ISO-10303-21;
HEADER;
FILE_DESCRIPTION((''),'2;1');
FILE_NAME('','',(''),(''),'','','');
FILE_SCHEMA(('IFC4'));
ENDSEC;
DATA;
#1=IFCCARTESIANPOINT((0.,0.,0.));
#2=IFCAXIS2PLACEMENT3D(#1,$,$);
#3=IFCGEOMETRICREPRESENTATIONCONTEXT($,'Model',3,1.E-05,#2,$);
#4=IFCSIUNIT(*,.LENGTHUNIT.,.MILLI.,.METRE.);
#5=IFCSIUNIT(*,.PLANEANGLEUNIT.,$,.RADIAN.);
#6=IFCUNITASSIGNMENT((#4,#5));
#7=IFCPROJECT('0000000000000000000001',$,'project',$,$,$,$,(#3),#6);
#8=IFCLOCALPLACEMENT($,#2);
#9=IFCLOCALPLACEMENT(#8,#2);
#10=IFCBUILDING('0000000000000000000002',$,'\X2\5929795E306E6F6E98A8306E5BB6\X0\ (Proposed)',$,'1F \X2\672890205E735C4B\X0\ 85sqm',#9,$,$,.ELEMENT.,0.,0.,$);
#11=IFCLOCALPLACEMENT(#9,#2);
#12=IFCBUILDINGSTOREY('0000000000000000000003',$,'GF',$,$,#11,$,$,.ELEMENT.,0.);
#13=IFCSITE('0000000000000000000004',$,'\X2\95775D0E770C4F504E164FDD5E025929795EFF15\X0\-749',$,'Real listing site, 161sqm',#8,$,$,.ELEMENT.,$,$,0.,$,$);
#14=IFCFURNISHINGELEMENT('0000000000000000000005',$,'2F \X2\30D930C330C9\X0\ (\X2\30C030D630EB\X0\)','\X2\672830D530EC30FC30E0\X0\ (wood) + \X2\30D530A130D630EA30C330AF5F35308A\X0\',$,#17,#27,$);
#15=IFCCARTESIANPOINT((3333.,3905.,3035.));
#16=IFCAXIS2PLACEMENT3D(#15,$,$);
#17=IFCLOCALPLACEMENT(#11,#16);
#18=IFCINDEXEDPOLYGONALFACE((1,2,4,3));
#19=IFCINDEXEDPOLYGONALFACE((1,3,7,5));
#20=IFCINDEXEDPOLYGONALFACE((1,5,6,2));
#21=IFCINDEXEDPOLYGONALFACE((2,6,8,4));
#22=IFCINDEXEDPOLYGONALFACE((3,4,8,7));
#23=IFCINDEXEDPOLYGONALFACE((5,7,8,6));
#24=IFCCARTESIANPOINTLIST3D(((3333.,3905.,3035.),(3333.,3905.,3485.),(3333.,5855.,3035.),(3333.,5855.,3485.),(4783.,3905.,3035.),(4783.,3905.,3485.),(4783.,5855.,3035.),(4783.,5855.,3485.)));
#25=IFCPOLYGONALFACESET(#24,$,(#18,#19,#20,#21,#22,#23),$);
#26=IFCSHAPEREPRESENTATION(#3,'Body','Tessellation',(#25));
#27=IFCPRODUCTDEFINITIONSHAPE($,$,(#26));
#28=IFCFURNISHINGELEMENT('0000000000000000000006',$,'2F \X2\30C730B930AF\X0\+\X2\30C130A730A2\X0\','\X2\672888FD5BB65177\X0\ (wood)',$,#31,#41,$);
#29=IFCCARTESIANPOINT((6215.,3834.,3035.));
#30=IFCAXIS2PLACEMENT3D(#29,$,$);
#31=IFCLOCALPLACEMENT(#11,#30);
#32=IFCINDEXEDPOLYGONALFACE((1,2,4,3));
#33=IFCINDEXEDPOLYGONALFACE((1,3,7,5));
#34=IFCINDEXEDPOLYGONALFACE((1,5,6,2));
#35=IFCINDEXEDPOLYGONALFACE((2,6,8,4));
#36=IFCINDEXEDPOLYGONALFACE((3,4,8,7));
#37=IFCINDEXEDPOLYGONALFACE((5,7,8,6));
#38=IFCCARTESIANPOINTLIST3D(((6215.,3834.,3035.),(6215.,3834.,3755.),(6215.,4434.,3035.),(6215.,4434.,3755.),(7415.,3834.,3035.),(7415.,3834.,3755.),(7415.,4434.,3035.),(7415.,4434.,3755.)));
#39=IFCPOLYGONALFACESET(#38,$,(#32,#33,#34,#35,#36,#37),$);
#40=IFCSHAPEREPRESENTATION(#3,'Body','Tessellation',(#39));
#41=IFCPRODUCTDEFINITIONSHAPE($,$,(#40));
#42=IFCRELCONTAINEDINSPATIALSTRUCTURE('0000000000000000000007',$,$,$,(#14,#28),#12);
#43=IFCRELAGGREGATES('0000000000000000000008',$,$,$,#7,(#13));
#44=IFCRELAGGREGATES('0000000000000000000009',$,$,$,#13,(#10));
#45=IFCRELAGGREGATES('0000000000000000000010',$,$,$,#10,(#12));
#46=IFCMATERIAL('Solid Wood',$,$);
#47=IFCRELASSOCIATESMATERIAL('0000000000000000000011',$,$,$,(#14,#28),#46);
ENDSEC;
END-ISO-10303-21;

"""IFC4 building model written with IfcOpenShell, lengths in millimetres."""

from ifc_helpers import new_model, si_unit, frame, frame_2d, origin, place, context, project, spatial, rectangle, extrude, material, element, save


model = new_model("IFC4")

# Units and contexts
model_context = context("Model", 3, precision=1e-05, world=origin())
ifc_project = project(units=[si_unit("LENGTHUNIT", "METRE", prefix="MILLI"), si_unit("PLANEANGLEUNIT", "RADIAN")], contexts=[model_context])

# Site, building, storey
site_placement = place(None, origin())
site = spatial("IfcSite", under=ifc_project, at=site_placement, Name="長崎県佐世保市天神５-749", ObjectType="Real listing site, 161sqm", CompositionType="ELEMENT", RefElevation=0.0)
building_placement = place(site_placement, origin())
building = spatial("IfcBuilding", under=site, at=building_placement, Name="天神の潮風の家 (Proposed)", ObjectType="1F 木造平屋 85sqm", CompositionType="ELEMENT", ElevationOfRefHeight=0.0, ElevationOfTerrain=0.0)
storey_placement = place(building_placement, origin())
storey = spatial("IfcBuildingStorey", under=building, at=storey_placement, Name="GF", CompositionType="ELEMENT", Elevation=0.0)

# Shared definitions
ifc_material_1 = material(Name="Solid Wood")

# Furnishing elements
furnishing_1_placement = place(storey_placement, frame((3333.0, 3905.0, 3035.0)))
element("IfcFurnishingElement", 1, at=furnishing_1_placement, inside=storey, material=ifc_material_1, Name="2F ベッド (ダブル)", Description="木フレーム (wood) + ファブリック張り", context=model_context, shape_type="SweptSolid", body=[
    extrude(rectangle(XDim=1450.0, YDim=1950.0, at=frame_2d((725.0, 975.0))), frame((3333.0, 3905.0, 3035.0)), (0.0, 0.0, 1.0), 450.0),
])
furnishing_2_placement = place(storey_placement, frame((6215.0, 3834.0, 3035.0)))
element("IfcFurnishingElement", 2, at=furnishing_2_placement, inside=storey, material=ifc_material_1, Name="2F デスク+チェア", Description="木製家具 (wood)", context=model_context, shape_type="SweptSolid", body=[
    extrude(rectangle(XDim=1200.0, YDim=600.0, at=frame_2d((600.0, 300.0))), frame((6215.0, 3834.0, 3035.0)), (0.0, 0.0, 1.0), 720.0),
])

save(model, "model.ifc")
